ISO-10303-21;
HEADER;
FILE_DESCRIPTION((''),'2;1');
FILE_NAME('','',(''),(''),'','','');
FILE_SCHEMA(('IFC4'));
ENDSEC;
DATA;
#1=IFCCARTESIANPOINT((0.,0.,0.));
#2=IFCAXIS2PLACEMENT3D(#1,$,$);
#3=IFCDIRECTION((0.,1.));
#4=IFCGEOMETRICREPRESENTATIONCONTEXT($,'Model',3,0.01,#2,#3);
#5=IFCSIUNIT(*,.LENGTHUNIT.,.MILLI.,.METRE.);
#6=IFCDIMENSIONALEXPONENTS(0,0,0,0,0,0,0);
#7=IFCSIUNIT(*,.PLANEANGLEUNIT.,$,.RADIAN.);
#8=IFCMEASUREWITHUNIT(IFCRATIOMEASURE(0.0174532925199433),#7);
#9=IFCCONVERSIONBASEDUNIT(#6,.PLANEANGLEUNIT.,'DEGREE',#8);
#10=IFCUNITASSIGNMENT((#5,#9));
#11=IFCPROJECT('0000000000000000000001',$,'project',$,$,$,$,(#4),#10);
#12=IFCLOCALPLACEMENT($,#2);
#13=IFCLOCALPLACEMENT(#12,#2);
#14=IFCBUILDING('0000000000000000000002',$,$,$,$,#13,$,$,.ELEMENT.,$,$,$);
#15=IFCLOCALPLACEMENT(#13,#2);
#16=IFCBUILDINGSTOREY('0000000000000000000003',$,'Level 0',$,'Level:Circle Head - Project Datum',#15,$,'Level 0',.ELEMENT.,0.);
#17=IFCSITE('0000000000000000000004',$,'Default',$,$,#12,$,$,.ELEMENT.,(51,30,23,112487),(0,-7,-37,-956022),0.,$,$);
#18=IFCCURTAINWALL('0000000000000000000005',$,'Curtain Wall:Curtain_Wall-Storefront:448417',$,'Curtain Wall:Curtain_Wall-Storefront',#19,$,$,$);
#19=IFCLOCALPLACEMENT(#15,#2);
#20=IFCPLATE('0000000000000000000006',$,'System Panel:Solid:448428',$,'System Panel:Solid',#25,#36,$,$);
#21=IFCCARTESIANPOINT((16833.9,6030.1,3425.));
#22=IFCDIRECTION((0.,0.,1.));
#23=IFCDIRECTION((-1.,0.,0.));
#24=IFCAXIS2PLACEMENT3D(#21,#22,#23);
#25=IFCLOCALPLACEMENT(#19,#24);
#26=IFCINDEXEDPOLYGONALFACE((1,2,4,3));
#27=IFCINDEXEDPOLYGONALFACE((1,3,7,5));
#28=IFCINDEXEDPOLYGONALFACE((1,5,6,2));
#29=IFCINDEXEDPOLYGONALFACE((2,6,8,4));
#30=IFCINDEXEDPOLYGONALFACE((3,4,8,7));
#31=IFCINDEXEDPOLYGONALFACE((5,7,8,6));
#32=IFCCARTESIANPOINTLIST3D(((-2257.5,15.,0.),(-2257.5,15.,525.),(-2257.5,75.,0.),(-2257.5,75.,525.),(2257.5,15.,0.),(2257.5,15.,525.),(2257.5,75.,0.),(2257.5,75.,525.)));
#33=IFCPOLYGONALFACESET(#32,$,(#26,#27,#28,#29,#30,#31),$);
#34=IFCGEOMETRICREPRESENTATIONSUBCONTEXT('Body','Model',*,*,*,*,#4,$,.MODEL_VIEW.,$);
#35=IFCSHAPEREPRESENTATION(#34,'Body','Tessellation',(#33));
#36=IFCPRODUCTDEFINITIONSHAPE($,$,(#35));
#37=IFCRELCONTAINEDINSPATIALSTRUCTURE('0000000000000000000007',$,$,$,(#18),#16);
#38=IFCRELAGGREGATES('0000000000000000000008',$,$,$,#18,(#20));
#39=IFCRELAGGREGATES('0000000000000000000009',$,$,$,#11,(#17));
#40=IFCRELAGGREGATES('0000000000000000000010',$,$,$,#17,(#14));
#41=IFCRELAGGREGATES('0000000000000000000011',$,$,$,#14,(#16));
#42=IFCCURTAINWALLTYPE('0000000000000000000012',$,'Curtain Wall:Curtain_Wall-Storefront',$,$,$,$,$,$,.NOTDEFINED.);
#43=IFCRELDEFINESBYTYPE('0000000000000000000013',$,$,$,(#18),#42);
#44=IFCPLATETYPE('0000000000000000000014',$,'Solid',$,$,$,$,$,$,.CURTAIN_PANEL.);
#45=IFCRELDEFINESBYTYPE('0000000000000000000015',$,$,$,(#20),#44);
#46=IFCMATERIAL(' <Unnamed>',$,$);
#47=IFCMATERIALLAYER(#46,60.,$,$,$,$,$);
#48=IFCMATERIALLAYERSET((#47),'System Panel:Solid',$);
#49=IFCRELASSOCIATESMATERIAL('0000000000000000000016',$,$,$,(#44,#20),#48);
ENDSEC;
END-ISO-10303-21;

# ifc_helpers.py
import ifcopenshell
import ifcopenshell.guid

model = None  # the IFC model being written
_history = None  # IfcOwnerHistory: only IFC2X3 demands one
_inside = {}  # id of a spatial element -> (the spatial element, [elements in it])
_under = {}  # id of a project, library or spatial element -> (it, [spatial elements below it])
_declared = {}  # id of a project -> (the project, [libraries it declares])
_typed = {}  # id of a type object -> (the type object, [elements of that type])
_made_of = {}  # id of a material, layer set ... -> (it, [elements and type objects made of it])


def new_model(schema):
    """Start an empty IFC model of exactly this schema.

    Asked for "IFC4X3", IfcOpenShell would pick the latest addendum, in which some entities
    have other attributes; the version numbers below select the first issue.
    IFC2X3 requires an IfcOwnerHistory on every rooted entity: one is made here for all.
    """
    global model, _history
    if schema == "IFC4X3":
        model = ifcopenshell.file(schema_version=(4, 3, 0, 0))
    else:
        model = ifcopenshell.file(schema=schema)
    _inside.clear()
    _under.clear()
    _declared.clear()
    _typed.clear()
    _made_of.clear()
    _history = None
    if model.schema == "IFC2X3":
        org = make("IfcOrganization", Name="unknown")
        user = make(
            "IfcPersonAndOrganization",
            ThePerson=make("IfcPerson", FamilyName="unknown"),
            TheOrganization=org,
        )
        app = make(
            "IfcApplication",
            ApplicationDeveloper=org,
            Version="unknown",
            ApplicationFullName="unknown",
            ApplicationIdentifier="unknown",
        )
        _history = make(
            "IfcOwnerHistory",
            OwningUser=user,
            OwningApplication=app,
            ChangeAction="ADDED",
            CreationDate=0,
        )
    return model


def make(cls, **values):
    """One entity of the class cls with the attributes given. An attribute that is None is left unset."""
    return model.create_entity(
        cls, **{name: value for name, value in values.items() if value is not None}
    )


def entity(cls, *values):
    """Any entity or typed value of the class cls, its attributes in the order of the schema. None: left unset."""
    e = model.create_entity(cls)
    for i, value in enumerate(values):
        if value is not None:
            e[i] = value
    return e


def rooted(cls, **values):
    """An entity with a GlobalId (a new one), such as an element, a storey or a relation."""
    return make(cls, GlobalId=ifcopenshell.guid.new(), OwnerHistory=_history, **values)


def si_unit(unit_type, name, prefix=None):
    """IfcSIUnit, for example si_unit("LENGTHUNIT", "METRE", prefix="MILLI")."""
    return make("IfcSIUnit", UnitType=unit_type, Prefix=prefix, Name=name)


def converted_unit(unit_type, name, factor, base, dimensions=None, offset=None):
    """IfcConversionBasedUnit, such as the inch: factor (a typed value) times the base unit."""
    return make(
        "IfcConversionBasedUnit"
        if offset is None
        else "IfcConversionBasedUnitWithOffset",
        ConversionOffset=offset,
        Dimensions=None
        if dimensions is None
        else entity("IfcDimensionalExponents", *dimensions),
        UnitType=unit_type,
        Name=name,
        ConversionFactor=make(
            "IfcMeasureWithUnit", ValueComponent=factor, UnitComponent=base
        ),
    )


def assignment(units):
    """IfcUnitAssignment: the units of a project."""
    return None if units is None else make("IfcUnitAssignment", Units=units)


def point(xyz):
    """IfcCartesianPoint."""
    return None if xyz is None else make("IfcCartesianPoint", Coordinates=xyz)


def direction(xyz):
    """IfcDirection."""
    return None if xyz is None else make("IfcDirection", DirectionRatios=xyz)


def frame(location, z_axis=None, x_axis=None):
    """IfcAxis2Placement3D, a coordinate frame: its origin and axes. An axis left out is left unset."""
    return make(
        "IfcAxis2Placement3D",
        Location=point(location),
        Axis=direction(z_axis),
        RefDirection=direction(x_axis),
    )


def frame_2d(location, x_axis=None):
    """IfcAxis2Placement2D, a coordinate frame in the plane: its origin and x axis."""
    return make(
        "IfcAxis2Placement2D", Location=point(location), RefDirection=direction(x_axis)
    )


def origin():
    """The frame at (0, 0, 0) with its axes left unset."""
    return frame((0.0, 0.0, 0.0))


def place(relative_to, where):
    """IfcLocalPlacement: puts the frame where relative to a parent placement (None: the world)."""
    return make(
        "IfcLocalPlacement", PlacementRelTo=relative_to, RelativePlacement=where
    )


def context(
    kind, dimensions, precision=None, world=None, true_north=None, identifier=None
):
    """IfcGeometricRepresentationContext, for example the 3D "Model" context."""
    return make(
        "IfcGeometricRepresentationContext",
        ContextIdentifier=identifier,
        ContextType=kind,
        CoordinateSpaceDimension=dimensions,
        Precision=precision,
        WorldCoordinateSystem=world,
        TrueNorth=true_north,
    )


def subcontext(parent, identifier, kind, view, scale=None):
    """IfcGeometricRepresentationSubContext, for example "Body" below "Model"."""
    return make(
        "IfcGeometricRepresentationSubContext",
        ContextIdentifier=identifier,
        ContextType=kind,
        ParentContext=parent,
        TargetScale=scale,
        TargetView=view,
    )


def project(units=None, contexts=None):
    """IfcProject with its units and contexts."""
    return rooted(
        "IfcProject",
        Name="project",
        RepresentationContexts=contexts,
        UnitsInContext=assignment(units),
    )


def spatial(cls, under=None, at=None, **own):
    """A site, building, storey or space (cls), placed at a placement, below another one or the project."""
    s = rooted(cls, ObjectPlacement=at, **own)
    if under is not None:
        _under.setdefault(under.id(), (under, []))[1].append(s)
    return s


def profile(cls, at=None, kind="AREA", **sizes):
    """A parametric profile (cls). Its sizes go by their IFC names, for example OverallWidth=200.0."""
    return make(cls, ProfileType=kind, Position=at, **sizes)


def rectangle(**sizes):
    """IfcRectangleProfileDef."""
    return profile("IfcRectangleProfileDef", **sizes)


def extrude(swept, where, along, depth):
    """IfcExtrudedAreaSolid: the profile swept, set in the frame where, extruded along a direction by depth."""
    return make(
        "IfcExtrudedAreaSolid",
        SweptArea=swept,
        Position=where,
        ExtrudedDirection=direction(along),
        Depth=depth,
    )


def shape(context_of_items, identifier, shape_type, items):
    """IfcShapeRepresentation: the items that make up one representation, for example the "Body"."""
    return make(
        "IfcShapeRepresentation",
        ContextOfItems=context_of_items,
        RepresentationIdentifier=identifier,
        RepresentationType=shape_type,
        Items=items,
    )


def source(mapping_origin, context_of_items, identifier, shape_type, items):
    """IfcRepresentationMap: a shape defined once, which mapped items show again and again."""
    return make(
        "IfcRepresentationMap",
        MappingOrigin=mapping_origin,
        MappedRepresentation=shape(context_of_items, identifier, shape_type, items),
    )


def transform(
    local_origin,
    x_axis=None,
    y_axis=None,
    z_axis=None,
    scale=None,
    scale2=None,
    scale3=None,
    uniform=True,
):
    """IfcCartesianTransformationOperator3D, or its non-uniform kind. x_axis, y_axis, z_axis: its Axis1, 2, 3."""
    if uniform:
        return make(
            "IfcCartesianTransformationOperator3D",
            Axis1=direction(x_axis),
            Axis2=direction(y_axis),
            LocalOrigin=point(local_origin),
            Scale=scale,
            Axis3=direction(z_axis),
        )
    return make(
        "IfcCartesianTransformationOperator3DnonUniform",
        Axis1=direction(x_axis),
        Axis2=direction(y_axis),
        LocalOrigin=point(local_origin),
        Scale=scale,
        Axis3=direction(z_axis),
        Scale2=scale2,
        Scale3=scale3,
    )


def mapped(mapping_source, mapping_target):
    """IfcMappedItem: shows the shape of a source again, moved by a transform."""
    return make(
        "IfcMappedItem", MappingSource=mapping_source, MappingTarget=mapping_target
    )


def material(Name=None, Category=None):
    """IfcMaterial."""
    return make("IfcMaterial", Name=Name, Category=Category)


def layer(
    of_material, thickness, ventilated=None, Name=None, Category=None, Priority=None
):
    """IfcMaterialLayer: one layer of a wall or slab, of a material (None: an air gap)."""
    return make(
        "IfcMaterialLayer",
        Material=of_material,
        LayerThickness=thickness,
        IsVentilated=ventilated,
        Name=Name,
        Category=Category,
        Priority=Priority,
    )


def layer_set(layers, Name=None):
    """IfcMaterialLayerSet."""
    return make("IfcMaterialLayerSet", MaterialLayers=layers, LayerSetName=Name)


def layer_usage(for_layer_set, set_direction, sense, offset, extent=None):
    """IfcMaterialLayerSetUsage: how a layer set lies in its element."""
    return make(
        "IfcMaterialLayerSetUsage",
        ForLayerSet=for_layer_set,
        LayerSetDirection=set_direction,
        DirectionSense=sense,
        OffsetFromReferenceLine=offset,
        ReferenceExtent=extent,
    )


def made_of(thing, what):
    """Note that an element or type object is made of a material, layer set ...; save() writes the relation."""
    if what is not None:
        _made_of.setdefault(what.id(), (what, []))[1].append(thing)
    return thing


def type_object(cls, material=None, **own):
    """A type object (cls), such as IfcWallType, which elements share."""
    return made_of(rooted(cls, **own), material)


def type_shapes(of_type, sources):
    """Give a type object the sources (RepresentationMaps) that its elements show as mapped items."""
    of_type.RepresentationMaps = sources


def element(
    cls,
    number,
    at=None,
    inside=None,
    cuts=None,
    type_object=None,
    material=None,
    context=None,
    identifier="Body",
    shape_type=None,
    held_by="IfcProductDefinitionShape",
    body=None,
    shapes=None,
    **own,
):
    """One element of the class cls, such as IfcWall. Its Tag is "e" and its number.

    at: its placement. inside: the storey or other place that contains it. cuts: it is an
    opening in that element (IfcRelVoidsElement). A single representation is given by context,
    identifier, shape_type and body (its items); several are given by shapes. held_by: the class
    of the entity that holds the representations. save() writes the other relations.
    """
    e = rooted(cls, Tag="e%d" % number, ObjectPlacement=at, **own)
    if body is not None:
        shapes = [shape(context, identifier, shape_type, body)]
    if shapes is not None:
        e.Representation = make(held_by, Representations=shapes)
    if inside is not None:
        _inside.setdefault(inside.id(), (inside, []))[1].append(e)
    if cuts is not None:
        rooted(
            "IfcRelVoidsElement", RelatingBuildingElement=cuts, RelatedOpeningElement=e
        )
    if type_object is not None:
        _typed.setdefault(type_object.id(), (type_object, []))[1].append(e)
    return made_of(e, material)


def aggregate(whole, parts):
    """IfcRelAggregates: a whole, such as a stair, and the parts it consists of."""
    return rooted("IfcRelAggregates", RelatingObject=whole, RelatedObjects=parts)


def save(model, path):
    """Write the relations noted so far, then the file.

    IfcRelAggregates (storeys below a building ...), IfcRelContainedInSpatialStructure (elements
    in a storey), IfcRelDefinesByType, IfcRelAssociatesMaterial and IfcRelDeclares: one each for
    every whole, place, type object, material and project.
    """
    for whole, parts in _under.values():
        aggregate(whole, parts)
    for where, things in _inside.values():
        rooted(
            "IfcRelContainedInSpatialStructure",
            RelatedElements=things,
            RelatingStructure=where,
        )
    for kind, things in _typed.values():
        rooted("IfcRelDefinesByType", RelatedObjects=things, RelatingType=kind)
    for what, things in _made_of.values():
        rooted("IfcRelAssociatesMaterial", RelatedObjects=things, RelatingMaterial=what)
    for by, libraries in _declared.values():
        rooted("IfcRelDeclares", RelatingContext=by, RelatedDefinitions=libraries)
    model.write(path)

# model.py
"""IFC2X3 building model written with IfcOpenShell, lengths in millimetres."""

from ifc_helpers import new_model, entity, si_unit, converted_unit, direction, frame, frame_2d, origin, place, context, subcontext, project, spatial, rectangle, extrude, source, transform, mapped, material, layer, layer_set, layer_usage, type_object, type_shapes, element, aggregate, save


model = new_model("IFC2X3")

# Units and contexts
model_context = context("Model", 3, precision=0.01, world=origin(), true_north=direction((0.0, 1.0)))
body_context = subcontext(model_context, "Body", "Model", "MODEL_VIEW")
ifc_project = project(units=[si_unit("LENGTHUNIT", "METRE", prefix="MILLI"), converted_unit("PLANEANGLEUNIT", "DEGREE", entity("IfcRatioMeasure", 0.0174532925199433), si_unit("PLANEANGLEUNIT", "RADIAN"), dimensions=[0, 0, 0, 0, 0, 0, 0])], contexts=[model_context])

# Site, building, storey
site_placement = place(None, origin())
site = spatial("IfcSite", under=ifc_project, at=site_placement, Name="Default", CompositionType="ELEMENT", RefLatitude=(51, 30, 23, 112487), RefLongitude=(0, -7, -37, -956022), RefElevation=0.0)
building_placement = place(site_placement, origin())
building = spatial("IfcBuilding", under=site, at=building_placement, CompositionType="ELEMENT")
storey_placement = place(building_placement, origin())
storey = spatial("IfcBuildingStorey", under=building, at=storey_placement, Name="Level 0", ObjectType="Level:Circle Head - Project Datum", LongName="Level 0", CompositionType="ELEMENT", Elevation=0.0)

# Curtain wall
curtain_wall_type = type_object("IfcCurtainWallType", Name="Curtain Wall:Curtain_Wall-Storefront", PredefinedType="NOTDEFINED")
curtain_wall_1_placement = place(storey_placement, origin())
curtain_wall_1 = element("IfcCurtainWall", 1, at=curtain_wall_1_placement, inside=storey, type_object=curtain_wall_type, Name="Curtain Wall:Curtain_Wall-Storefront:448417", ObjectType="Curtain Wall:Curtain_Wall-Storefront")

# Plate
ifc_material_1 = material(Name=" <Unnamed>")
ifc_layer_1 = layer(ifc_material_1, 60.0)
ifc_layer_set_1 = layer_set([ifc_layer_1], Name="System Panel:Solid")
ifc_layer_usage_1 = layer_usage(ifc_layer_set_1, "AXIS3", "POSITIVE", 0.1)
plate_type_1 = type_object("IfcPlateType", Name="Solid", PredefinedType="CURTAIN_PANEL", material=ifc_layer_set_1)
shared_shape_1 = source(origin(), body_context, "Body", "SweptSolid", [
    extrude(rectangle(XDim=525.0, YDim=4515.0, at=frame_2d((0.0, 3.8), x_axis=(1.0, 0.0))), frame((-3.8, 15.0, 262.5), z_axis=(0.0, 1.0, 0.0), x_axis=(0.0, 0.0, 1.0)), (0.0, 0.0, 1.0), 60.0),
])
type_shapes(plate_type_1, [shared_shape_1])
plate_1_placement = place(curtain_wall_1_placement, frame((16833.9, 6030.1, 3425.0), z_axis=(0.0, 0.0, 1.0), x_axis=(-1.0, 0.0, 0.0)))
plate_1 = element("IfcPlate", 2, at=plate_1_placement, type_object=plate_type_1, material=ifc_layer_usage_1, Name="System Panel:Solid:448428", ObjectType="System Panel:Solid", context=body_context, shape_type="MappedRepresentation", body=[
    mapped(shared_shape_1, transform((0.0, 0.0, 0.0), scale=1.0)),
])
aggregate(curtain_wall_1, [plate_1])

save(model, "model.ifc")
